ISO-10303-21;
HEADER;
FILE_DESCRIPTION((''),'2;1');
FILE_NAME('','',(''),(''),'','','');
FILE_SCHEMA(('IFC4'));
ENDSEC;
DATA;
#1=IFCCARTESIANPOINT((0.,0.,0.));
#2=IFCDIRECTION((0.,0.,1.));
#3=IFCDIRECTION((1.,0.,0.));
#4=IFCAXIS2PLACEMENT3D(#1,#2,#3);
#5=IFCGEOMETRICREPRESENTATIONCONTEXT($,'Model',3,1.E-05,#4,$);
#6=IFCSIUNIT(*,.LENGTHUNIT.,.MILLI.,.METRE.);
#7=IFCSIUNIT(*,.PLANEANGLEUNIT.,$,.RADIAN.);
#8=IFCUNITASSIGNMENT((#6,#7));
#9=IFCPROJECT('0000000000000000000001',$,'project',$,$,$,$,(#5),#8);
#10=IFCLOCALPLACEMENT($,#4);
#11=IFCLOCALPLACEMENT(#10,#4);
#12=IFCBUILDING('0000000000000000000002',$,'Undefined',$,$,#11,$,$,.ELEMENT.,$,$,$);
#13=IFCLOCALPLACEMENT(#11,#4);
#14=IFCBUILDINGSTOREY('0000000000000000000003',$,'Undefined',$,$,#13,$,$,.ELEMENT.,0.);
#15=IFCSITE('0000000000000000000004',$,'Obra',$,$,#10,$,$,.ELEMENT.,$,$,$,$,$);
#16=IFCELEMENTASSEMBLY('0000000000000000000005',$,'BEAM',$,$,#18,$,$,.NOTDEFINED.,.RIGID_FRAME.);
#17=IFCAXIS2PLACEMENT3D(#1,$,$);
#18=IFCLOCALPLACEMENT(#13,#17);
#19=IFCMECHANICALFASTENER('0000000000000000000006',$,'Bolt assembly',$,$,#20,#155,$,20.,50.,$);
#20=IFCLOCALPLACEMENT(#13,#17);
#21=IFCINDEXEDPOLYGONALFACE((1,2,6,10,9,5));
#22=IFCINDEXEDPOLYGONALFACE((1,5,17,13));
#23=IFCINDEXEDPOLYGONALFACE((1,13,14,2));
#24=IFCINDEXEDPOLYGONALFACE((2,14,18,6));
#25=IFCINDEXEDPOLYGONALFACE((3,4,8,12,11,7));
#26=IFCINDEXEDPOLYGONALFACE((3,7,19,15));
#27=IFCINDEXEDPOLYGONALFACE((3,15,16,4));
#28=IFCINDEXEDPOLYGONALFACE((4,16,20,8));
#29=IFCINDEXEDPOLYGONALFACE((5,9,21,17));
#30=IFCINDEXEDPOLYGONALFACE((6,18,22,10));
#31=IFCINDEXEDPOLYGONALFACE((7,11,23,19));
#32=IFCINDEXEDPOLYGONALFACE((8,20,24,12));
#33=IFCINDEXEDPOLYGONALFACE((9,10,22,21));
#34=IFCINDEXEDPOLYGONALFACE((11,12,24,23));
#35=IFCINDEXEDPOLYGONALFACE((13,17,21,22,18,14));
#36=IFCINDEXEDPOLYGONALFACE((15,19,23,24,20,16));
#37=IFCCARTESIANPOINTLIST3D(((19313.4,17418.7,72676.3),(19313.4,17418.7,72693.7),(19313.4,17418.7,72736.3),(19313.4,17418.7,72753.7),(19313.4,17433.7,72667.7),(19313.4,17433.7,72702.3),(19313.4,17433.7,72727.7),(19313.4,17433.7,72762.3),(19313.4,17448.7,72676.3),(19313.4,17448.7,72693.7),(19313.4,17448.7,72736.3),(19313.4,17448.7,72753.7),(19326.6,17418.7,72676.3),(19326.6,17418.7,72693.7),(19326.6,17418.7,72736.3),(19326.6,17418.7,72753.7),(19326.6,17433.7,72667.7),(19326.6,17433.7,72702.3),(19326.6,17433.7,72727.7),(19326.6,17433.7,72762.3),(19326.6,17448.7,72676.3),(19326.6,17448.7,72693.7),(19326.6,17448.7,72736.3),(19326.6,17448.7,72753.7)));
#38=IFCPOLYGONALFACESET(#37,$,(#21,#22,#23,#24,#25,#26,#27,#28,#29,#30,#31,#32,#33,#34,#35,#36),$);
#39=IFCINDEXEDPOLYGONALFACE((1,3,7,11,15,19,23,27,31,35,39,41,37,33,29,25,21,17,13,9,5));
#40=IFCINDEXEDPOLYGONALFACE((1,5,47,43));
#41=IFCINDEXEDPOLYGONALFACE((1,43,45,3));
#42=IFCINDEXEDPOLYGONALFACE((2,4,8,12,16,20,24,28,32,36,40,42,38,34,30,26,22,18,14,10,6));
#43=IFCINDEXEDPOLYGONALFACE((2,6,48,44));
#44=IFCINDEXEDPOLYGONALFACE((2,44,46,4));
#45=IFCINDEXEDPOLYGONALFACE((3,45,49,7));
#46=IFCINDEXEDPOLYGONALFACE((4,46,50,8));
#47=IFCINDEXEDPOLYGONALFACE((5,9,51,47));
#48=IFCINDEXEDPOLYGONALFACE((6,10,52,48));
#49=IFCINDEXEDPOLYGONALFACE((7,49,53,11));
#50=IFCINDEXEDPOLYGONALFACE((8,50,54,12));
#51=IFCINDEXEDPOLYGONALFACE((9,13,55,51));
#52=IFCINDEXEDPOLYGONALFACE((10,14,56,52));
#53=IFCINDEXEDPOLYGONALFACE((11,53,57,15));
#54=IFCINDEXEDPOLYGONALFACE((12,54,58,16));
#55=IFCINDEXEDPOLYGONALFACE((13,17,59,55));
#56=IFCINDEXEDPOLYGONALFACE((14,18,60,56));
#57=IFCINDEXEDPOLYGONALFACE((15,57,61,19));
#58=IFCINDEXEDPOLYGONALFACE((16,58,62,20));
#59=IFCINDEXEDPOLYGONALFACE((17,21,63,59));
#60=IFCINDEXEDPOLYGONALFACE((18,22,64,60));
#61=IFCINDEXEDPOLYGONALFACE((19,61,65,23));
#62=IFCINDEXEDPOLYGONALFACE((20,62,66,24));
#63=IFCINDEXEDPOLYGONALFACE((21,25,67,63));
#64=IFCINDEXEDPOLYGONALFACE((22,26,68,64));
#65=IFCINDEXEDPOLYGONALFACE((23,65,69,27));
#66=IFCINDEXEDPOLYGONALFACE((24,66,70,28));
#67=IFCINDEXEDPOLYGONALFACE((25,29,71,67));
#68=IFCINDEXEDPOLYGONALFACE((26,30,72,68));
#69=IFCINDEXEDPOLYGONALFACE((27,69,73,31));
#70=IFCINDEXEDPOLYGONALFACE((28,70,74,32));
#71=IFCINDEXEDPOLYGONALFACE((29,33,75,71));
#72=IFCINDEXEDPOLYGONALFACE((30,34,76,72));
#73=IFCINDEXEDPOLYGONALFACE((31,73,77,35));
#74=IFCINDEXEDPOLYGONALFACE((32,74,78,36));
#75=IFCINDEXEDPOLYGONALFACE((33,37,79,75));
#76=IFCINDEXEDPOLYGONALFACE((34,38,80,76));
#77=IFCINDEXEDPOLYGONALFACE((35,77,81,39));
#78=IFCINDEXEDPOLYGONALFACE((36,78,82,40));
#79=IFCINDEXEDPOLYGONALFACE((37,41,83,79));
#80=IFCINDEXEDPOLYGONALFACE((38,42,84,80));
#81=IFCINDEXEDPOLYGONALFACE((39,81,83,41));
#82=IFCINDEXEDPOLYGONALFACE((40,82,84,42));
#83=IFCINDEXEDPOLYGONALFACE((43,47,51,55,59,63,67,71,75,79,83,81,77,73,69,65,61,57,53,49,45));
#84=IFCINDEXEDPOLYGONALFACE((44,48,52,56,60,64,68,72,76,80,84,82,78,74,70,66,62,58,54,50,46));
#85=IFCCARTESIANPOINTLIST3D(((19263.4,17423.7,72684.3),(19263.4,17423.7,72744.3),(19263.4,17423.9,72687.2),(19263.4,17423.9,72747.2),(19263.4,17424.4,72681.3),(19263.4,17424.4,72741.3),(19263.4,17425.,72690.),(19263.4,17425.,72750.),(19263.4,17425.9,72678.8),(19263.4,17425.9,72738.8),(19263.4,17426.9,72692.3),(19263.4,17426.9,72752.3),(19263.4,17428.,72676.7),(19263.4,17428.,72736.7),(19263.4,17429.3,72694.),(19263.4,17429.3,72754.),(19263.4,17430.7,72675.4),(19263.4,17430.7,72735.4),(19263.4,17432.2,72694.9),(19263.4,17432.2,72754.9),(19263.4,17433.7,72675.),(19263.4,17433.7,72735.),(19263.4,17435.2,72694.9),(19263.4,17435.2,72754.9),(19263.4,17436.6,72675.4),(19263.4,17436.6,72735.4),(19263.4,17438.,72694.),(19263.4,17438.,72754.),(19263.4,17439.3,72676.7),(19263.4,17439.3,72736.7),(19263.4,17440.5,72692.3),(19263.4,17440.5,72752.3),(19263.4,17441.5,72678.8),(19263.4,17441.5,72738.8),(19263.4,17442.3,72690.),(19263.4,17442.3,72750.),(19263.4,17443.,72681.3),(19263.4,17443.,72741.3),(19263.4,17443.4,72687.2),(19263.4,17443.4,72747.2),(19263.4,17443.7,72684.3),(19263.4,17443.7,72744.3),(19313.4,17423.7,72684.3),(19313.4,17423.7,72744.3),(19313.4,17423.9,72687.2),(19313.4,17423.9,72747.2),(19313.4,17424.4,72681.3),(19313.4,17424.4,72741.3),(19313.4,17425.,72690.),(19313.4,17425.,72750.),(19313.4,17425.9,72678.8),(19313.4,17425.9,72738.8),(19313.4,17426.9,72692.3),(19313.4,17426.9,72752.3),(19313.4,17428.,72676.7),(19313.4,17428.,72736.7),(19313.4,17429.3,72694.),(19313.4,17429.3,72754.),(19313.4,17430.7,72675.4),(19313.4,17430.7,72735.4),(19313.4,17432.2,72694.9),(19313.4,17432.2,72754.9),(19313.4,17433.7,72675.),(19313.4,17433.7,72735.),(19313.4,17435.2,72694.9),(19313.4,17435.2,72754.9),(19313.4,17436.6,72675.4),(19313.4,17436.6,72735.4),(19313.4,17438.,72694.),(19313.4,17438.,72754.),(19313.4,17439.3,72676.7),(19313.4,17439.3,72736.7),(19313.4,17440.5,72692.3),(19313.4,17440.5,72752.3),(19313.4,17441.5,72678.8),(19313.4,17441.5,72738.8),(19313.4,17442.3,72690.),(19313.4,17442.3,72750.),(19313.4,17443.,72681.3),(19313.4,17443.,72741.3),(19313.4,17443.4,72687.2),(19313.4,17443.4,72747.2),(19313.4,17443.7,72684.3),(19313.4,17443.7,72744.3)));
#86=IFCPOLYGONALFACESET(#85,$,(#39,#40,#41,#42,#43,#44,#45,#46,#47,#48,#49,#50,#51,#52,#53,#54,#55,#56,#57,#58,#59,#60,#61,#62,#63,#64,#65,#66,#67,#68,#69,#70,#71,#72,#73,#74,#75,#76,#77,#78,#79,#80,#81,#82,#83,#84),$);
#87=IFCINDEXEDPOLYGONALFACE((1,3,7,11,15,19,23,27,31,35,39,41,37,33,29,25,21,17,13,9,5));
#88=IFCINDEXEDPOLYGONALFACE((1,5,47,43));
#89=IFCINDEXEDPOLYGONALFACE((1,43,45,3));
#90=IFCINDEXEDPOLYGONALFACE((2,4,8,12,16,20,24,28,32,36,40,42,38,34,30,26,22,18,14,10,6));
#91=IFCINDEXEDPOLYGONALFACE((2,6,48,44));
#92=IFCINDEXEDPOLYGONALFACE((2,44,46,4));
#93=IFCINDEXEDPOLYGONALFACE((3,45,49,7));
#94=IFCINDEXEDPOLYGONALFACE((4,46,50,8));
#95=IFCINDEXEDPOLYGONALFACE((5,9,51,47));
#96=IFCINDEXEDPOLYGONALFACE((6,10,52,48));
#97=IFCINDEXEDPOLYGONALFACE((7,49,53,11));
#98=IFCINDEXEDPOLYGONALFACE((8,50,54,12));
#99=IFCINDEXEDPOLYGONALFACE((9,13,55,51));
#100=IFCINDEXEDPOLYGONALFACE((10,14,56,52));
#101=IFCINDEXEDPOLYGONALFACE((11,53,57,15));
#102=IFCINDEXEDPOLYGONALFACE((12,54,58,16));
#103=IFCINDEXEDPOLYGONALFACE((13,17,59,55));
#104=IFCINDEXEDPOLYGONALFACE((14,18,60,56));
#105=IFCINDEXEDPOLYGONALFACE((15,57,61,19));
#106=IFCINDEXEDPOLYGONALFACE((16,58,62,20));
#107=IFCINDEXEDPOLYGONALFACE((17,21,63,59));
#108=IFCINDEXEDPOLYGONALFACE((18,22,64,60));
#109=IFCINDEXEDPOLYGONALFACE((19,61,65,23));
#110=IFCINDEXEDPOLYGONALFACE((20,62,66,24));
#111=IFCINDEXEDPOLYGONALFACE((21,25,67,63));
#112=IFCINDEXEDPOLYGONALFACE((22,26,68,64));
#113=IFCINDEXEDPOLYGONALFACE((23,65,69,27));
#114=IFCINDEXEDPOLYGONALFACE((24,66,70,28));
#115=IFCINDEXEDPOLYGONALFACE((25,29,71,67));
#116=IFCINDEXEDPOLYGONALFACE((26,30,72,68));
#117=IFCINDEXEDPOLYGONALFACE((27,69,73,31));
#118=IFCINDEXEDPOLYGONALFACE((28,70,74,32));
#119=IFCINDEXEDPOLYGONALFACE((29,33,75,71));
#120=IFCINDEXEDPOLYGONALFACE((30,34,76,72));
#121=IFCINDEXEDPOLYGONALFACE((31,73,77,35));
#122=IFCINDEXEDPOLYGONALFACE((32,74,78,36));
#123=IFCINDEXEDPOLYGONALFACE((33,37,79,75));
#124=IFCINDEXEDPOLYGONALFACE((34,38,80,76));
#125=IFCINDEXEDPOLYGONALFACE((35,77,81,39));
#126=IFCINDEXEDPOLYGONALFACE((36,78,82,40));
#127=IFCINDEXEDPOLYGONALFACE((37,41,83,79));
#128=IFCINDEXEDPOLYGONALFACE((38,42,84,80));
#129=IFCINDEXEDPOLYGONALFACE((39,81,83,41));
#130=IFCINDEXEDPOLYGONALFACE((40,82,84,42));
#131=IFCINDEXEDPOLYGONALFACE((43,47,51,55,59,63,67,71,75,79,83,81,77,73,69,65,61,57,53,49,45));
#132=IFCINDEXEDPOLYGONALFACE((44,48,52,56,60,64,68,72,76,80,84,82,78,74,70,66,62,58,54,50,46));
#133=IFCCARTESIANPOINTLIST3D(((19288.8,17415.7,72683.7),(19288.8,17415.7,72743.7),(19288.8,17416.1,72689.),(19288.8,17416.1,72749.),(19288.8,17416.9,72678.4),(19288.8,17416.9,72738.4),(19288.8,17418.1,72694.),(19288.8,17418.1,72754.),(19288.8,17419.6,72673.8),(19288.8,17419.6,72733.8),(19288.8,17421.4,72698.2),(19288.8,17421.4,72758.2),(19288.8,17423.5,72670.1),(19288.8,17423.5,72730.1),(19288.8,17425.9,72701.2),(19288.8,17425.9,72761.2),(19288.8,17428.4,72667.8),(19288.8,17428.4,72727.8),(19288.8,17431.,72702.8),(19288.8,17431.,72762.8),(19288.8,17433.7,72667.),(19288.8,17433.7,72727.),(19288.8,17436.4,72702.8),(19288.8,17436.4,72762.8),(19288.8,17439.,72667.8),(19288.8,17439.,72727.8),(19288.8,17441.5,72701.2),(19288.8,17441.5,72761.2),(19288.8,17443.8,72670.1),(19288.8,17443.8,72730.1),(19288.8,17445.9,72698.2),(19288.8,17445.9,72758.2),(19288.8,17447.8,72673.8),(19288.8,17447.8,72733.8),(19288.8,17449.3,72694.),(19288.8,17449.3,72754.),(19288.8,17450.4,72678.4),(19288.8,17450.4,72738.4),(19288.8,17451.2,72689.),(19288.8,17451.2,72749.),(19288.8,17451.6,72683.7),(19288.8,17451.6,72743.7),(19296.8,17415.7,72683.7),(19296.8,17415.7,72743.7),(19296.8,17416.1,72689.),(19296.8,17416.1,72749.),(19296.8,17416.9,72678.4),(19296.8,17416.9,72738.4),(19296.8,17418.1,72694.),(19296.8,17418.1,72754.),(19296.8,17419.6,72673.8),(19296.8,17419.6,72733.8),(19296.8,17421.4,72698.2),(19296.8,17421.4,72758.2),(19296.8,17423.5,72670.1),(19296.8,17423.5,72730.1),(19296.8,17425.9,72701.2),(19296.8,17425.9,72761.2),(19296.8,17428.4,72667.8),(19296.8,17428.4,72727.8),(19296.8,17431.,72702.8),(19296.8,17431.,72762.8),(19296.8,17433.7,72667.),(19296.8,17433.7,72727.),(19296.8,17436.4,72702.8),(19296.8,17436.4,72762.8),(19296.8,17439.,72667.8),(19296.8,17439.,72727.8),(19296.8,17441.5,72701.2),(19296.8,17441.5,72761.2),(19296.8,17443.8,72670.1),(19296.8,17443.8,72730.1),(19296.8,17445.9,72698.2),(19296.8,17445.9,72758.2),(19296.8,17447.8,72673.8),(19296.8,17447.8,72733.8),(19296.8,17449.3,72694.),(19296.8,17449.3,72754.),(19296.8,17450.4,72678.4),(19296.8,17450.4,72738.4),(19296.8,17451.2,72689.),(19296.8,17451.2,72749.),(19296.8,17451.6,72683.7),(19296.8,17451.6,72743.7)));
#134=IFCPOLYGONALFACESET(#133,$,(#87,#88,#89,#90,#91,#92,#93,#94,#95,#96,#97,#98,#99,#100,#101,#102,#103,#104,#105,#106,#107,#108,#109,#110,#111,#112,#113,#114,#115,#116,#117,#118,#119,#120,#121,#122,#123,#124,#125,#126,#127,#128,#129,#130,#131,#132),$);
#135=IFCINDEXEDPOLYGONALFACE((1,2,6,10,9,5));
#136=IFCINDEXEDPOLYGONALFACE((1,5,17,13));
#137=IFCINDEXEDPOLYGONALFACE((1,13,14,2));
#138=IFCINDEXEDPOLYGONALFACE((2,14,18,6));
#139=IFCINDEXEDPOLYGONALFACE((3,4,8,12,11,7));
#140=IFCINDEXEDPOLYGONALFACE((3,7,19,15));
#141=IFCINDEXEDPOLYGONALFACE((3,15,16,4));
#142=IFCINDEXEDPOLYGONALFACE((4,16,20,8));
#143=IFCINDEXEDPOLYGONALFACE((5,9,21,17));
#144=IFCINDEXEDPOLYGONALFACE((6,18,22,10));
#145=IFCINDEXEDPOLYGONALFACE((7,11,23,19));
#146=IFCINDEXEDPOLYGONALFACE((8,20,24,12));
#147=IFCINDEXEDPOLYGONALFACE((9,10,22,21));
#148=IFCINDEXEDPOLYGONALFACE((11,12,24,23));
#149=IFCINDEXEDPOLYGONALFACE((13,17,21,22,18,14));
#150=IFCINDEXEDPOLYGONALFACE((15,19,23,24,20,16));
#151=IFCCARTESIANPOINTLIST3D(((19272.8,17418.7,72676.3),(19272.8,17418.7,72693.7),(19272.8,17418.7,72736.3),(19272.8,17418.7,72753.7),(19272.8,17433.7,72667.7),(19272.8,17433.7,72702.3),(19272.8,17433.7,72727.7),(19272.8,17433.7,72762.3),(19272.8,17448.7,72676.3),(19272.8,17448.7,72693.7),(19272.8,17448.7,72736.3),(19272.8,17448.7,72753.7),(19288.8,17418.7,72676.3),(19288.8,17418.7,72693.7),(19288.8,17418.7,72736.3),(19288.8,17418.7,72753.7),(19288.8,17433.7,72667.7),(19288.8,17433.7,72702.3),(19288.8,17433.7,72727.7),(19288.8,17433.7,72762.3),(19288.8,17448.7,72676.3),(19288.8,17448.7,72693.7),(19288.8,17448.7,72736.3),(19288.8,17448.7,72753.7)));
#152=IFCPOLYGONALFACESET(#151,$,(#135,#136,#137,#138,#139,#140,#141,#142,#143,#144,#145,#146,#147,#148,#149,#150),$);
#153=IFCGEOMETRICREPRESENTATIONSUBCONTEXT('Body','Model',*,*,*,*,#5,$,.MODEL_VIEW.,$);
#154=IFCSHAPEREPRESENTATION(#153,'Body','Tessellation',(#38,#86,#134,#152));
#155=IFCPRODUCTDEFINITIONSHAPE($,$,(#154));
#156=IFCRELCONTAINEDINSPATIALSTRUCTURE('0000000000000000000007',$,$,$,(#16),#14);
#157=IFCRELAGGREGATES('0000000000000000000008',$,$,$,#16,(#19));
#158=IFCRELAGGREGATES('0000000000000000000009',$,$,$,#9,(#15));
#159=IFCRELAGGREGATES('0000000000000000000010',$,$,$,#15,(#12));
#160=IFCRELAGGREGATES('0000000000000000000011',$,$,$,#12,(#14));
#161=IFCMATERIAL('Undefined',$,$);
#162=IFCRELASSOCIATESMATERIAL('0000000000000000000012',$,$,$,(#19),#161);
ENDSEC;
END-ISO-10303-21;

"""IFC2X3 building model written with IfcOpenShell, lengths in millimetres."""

from ifc_helpers import new_model, si_unit, frame, origin_with_axes, origin_2d_with_axis, place, context, subcontext, project, spatial, polyline, circle, outline, extrude, source, transform, mapped, material, element, aggregate, save


model = new_model("IFC2X3")

# Units and contexts
model_context = context("Model", 3, precision=1e-05, world=origin_with_axes())
body_context = subcontext(model_context, "Body", "Model", "MODEL_VIEW")
ifc_project = project(units=[si_unit("LENGTHUNIT", "METRE", prefix="MILLI"), si_unit("PLANEANGLEUNIT", "RADIAN")], contexts=[model_context])

# Site, building, storey
site_placement = place(None, origin_with_axes())
site = spatial("IfcSite", under=ifc_project, at=site_placement, Name="Obra", CompositionType="ELEMENT")
building_placement = place(site_placement, origin_with_axes())
building = spatial("IfcBuilding", under=site, at=building_placement, Name="Undefined", CompositionType="ELEMENT")
storey_placement = place(building_placement, origin_with_axes())
storey = spatial("IfcBuildingStorey", under=building, at=storey_placement, Name="Undefined", CompositionType="ELEMENT", Elevation=0.0)

# Shared definitions
ifc_material = material(Name="Undefined")

# Element assembly, mechanical fastener
assembly_1_placement = place(storey_placement, origin_with_axes())
assembly_1 = element("IfcElementAssembly", 1, at=assembly_1_placement, inside=storey, Name="BEAM", AssemblyPlace="NOTDEFINED", PredefinedType="RIGID_FRAME")
shared_shape_1 = source(origin_with_axes(), body_context, "Body", "SweptSolid", [
    extrude(outline(polyline([(17.3, 0.0), (8.7, 15.0), (-8.7, 15.0), (-17.3, 0.0), (-8.7, -15.0), (8.7, -15.0), (17.3, 0.0)])), frame((0.0, -26.5, 0.0), z_axis=(0.0, 1.0, 0.0), x_axis=(1.0, 0.0, 0.0)), (0.0, 0.0, 1.0), 13.2),
    extrude(circle(Radius=10.0, at=origin_2d_with_axis()), frame((0.0, -13.3, 0.0), z_axis=(0.0, 1.0, 0.0), x_axis=(1.0, 0.0, 0.0)), (0.0, 0.0, 1.0), 50.0),
    extrude(circle(Radius=18.0, at=origin_2d_with_axis()), frame((0.0, 3.3, 0.0), z_axis=(0.0, 1.0, 0.0), x_axis=(1.0, 0.0, 0.0)), (0.0, 0.0, 1.0), 8.0),
    extrude(outline(polyline([(17.3, 0.0), (8.7, 15.0), (-8.7, 15.0), (-17.3, 0.0), (-8.7, -15.0), (8.7, -15.0), (17.3, 0.0)])), frame((0.0, 11.3, 0.0), z_axis=(0.0, 1.0, 0.0), x_axis=(1.0, 0.0, 0.0)), (0.0, 0.0, 1.0), 16.0),
])
mechanical_fastener_1_placement = place(assembly_1_placement, frame((19300.1, 17393.7, 72850.0), z_axis=(0.0, 1.0, 0.0), x_axis=(0.0, 0.0, -1.0)))
mechanical_fastener_1 = element("IfcMechanicalFastener", 2, at=mechanical_fastener_1_placement, material=ifc_material, Name="Bolt assembly", NominalDiameter=20.0, NominalLength=50.0, context=body_context, shape_type="MappedRepresentation", body=[
    mapped(shared_shape_1, transform((105.0, 0.0, 40.0))),
    mapped(shared_shape_1, transform((165.0, 0.0, 40.0))),
])
aggregate(assembly_1, [mechanical_fastener_1])

save(model, "model.ifc")
